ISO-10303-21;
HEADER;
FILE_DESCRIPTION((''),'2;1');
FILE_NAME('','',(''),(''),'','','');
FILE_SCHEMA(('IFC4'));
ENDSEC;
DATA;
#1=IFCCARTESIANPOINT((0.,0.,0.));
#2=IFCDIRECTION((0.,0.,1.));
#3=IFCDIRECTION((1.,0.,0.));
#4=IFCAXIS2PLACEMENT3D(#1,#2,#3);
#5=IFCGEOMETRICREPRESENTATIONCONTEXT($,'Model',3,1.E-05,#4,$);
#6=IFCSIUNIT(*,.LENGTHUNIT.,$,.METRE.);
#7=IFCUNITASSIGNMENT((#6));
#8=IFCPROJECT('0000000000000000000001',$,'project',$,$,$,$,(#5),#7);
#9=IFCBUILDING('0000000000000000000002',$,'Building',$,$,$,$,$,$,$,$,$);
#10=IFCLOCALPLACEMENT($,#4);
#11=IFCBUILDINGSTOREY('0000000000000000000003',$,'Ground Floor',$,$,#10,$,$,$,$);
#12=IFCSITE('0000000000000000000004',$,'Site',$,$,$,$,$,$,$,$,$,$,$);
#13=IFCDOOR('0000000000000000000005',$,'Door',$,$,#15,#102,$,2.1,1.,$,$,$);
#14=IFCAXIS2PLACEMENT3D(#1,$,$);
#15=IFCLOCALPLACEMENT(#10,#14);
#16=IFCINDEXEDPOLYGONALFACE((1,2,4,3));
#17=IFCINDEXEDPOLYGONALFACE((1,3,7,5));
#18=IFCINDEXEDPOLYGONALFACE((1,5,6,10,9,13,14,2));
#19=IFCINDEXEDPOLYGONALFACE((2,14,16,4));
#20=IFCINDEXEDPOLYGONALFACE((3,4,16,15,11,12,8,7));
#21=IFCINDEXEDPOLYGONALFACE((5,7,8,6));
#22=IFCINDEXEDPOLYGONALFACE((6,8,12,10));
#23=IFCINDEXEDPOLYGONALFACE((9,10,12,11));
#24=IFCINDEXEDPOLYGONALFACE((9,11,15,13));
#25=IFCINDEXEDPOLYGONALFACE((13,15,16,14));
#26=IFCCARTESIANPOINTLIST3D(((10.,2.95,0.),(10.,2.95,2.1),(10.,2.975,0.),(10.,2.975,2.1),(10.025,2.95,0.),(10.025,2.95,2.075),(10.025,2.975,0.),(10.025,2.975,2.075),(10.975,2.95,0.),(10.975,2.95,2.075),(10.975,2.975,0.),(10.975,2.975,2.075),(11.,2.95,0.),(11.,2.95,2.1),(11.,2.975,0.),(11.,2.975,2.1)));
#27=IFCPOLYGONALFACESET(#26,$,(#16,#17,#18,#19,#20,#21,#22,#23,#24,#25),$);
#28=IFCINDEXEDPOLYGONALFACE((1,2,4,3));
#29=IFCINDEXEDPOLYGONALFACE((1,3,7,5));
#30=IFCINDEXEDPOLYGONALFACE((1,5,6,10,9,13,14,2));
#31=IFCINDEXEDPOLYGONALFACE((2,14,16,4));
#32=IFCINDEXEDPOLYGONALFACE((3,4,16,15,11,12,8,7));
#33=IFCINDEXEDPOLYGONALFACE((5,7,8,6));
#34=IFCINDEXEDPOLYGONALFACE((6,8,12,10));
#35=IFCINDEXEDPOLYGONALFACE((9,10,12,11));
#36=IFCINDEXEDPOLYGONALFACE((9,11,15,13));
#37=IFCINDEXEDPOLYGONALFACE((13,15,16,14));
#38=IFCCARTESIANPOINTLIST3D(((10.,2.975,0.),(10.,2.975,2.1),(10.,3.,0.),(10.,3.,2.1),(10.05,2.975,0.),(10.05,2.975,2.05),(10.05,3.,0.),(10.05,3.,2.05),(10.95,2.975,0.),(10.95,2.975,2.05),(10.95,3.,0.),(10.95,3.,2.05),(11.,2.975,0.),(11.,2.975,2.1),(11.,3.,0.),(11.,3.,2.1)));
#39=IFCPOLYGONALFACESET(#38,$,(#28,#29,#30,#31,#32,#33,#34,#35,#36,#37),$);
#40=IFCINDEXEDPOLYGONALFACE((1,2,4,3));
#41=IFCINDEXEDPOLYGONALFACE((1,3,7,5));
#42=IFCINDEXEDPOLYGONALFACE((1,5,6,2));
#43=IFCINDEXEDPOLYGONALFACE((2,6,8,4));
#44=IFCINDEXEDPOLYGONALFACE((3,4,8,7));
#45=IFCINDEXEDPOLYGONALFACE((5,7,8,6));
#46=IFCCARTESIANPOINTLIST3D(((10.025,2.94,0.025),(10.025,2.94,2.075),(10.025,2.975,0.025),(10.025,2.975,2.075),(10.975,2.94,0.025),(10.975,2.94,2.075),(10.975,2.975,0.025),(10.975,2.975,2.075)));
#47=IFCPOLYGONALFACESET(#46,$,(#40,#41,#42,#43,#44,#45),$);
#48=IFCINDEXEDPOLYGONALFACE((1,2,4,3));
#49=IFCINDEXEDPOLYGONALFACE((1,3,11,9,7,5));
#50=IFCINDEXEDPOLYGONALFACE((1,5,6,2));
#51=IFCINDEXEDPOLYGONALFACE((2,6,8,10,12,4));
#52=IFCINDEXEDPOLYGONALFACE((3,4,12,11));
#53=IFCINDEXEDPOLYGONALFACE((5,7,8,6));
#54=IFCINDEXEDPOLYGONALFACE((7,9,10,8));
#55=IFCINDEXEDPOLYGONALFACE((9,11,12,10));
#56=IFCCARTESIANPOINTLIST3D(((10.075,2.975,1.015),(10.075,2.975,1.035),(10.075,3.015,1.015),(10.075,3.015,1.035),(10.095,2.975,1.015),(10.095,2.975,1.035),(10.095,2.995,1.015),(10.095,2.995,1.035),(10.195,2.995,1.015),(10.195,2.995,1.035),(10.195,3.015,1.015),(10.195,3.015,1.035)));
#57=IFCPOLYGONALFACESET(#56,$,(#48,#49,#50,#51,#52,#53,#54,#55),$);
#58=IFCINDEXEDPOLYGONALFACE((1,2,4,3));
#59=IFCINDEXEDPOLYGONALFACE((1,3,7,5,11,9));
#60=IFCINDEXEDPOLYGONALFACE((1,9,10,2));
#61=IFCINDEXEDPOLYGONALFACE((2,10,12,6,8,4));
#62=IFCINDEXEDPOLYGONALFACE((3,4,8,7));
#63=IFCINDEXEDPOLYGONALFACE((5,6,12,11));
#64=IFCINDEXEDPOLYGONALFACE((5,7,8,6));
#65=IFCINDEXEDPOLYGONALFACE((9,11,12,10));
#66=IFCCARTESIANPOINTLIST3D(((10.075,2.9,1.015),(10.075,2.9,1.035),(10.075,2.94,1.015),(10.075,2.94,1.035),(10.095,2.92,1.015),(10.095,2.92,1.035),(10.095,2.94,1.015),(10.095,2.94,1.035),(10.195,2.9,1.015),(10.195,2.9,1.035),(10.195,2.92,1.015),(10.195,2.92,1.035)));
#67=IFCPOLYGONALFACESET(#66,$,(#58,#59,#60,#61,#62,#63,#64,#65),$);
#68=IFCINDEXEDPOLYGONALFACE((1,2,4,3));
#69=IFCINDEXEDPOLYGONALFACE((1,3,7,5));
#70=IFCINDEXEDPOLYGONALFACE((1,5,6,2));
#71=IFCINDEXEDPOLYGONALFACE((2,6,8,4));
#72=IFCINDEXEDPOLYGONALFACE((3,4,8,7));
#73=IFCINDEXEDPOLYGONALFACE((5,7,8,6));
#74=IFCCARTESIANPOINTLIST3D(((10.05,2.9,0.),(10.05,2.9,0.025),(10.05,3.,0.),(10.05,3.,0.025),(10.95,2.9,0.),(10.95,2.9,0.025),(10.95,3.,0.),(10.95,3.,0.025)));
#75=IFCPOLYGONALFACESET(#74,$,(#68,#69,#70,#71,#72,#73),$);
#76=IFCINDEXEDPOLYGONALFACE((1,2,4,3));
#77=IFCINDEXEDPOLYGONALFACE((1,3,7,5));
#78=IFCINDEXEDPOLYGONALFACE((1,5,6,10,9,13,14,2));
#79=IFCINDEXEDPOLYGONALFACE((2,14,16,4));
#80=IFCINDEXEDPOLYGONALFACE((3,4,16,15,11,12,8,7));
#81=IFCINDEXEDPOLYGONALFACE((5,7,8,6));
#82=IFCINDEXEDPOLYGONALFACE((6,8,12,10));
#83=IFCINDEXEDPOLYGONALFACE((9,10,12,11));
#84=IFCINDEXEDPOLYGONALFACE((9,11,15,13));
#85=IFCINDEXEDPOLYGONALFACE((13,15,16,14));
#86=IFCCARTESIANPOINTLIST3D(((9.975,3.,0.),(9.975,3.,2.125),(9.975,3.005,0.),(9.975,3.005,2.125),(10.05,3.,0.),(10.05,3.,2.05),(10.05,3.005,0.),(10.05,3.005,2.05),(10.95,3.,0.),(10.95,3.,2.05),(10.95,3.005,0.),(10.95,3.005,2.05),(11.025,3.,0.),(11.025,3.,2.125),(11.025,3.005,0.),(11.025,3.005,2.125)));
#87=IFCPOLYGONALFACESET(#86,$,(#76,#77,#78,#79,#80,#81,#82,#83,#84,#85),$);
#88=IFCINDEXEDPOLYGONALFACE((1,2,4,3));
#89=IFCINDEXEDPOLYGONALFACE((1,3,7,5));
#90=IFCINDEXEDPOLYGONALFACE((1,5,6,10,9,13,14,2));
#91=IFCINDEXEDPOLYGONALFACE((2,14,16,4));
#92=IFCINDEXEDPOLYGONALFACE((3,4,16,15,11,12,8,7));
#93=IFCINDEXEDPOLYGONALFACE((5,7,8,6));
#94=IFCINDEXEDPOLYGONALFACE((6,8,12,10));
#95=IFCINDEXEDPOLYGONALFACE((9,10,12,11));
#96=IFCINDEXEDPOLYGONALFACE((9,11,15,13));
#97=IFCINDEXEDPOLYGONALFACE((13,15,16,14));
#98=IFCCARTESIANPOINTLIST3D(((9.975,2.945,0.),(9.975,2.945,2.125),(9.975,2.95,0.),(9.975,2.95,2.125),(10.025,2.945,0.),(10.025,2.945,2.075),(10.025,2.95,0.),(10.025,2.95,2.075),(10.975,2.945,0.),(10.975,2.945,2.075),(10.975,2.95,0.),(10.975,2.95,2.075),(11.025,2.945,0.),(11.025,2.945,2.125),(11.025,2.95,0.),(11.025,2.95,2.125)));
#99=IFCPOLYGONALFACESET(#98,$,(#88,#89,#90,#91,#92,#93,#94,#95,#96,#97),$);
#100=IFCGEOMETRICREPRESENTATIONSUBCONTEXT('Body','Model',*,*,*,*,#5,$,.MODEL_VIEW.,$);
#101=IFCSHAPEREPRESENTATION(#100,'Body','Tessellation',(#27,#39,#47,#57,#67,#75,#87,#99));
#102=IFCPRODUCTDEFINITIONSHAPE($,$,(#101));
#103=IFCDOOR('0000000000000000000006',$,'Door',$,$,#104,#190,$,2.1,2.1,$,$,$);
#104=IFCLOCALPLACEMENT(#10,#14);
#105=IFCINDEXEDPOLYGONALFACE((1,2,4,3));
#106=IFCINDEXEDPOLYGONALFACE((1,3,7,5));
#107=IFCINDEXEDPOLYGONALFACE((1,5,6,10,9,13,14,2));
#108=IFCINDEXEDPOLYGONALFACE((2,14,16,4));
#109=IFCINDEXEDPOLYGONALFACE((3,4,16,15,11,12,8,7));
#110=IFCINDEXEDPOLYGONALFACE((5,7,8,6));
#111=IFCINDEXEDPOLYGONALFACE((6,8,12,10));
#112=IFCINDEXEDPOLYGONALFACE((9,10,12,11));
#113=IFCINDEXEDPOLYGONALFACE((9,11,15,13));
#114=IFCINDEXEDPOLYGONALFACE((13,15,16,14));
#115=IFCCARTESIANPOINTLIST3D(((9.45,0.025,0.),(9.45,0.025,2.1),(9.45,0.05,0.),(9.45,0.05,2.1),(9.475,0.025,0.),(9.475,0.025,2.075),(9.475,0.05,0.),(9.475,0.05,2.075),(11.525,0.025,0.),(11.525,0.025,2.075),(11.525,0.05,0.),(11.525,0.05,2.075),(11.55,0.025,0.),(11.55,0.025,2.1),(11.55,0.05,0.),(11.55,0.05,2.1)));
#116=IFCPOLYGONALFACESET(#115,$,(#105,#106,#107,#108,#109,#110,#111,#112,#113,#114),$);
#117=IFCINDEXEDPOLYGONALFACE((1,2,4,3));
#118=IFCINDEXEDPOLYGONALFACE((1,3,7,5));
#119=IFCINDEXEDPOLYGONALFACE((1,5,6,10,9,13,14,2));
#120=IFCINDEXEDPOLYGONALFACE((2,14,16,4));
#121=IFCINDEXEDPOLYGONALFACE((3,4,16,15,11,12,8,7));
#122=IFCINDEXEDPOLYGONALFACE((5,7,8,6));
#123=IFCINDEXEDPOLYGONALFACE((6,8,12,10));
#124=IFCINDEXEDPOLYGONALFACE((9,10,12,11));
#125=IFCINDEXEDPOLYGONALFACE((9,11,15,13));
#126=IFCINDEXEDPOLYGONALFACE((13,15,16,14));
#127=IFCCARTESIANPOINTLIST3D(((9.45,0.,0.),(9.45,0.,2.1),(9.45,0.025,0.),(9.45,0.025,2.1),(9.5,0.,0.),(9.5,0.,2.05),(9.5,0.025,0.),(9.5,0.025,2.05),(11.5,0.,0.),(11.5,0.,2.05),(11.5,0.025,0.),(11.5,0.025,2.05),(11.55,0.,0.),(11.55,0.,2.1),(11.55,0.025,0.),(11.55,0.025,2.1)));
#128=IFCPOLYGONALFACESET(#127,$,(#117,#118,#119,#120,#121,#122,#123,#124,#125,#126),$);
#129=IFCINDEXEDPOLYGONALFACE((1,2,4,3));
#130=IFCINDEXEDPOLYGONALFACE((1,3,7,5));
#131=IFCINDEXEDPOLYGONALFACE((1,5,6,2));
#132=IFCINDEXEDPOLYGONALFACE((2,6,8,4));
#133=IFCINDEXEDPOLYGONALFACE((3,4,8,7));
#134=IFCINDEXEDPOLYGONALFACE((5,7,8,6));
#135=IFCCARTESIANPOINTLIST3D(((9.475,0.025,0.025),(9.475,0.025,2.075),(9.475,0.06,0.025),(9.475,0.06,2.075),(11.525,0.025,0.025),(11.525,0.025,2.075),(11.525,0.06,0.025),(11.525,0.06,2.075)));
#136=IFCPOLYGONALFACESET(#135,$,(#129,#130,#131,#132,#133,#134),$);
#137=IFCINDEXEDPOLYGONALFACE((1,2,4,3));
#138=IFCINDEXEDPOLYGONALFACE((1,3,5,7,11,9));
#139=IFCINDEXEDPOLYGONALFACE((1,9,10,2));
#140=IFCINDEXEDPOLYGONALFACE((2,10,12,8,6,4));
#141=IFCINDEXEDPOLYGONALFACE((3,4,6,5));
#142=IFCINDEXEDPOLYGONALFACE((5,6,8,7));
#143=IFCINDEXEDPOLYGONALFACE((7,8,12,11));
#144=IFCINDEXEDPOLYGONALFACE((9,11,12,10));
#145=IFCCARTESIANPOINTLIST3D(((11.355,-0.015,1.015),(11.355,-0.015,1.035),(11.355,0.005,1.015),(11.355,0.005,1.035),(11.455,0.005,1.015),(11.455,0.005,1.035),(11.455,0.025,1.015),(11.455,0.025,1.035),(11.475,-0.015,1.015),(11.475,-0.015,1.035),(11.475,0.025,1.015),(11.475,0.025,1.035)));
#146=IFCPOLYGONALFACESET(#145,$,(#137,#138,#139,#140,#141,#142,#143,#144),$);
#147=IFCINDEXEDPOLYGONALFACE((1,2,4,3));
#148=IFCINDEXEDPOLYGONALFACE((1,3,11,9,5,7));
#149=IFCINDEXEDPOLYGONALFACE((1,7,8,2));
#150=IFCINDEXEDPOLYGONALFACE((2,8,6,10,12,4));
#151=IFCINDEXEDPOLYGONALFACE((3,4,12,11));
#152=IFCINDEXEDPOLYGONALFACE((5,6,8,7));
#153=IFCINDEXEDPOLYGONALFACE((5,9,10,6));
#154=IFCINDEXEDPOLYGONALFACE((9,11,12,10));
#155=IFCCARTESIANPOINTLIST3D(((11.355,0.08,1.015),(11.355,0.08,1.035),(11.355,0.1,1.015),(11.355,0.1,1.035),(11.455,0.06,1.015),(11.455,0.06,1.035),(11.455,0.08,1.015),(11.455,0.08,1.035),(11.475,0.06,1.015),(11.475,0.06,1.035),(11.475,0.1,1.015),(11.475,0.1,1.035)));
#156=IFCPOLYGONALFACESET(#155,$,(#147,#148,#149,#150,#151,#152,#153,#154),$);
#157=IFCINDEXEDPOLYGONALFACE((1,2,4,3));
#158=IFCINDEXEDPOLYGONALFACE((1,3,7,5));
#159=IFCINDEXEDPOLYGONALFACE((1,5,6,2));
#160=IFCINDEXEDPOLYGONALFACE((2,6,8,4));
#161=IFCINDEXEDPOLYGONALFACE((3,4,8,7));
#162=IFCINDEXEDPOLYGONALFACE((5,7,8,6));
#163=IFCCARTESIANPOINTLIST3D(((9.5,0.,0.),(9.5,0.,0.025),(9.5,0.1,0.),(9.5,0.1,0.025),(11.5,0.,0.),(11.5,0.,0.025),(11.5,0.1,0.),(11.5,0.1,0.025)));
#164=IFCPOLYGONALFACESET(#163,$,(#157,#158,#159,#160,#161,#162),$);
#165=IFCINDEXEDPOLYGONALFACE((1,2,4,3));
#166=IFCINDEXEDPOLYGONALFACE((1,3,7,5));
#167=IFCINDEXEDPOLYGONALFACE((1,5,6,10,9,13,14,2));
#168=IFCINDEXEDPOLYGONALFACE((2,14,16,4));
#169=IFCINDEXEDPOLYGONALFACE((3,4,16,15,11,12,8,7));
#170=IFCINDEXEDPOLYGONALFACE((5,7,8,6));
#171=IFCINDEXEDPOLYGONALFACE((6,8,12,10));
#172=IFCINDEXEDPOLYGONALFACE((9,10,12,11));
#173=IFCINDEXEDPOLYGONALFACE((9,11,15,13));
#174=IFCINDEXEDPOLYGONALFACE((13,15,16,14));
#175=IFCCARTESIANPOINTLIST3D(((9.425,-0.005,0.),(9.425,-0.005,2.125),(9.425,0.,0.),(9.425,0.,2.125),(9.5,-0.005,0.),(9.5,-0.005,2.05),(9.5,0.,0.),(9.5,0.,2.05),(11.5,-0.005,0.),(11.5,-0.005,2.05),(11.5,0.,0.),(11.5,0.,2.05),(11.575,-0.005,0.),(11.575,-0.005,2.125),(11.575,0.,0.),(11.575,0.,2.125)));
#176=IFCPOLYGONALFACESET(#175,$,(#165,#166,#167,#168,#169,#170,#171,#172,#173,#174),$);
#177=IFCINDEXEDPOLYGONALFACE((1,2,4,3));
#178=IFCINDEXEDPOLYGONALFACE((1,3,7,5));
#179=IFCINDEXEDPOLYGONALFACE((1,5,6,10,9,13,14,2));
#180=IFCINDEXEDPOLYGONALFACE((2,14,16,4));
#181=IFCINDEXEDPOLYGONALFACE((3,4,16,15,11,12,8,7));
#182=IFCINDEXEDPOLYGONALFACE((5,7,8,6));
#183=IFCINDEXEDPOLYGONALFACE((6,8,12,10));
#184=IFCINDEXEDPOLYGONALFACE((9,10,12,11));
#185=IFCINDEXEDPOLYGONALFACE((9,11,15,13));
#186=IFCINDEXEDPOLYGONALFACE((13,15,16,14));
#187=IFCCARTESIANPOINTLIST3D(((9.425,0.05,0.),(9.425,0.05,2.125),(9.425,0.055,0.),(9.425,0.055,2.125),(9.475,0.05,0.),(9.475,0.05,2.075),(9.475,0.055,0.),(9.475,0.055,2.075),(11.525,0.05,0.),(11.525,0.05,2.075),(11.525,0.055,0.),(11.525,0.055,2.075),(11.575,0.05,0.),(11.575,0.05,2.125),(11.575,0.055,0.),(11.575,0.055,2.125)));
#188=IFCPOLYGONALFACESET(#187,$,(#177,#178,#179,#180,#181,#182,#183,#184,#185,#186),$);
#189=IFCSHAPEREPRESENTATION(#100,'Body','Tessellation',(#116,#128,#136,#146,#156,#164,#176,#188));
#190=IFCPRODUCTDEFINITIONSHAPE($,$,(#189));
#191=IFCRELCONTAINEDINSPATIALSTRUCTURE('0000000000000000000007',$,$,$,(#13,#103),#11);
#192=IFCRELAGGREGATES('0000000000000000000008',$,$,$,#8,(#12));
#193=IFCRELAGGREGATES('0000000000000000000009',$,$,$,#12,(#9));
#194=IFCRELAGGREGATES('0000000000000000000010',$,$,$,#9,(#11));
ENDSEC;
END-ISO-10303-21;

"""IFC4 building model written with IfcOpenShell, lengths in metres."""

from ifc_helpers import new_model, si_unit, frame, origin_with_axes, place, context, subcontext, project, spatial, line, indexed_curve, outline, extrude, element, save


model = new_model("IFC4")

# Units and contexts
model_context = context("Model", 3, precision=1e-05, world=origin_with_axes())
body_context = subcontext(model_context, "Body", "Model", "MODEL_VIEW")
ifc_project = project(units=[si_unit("LENGTHUNIT", "METRE")], contexts=[model_context])

# Site, building, storey
site = spatial("IfcSite", under=ifc_project, Name="Site")
building = spatial("IfcBuilding", under=site, Name="Building")
storey_placement = place(None, origin_with_axes())
storey = spatial("IfcBuildingStorey", under=building, at=storey_placement, Name="Ground Floor")

# Doors
door_1_placement = place(storey_placement, frame((11.0, 3.0, 0.0), z_axis=(0.0, 0.0, 1.0), x_axis=(-1.0, 0.0, 0.0)))
element("IfcDoor", 1, at=door_1_placement, inside=storey, Name="Door", OverallHeight=2.1, OverallWidth=1.0, context=body_context, shape_type="SweptSolid", body=[
    extrude(outline(indexed_curve([(0.0, 0.0), (0.0, 2.1), (1.0, 2.1), (1.0, 0.0), (0.975, 0.0), (0.975, 2.075), (0.025, 2.075), (0.025, 0.0)], segments=[line(1, 2, 3, 4, 5, 6, 7, 8, 1)])), frame((0.0, 0.025, 0.0), z_axis=(0.0, -1.0, 0.0), x_axis=(1.0, 0.0, 0.0)), (0.0, 0.0, -1.0), 0.025),
    extrude(outline(indexed_curve([(0.0, 0.0), (0.0, 2.1), (1.0, 2.1), (1.0, 0.0), (0.95, 0.0), (0.95, 2.05), (0.05, 2.05), (0.05, 0.0)], segments=[line(1, 2, 3, 4, 5, 6, 7, 8, 1)])), frame((0.0, 0.0, 0.0), z_axis=(0.0, -1.0, 0.0), x_axis=(1.0, 0.0, 0.0)), (0.0, 0.0, -1.0), 0.025),
    extrude(outline(indexed_curve([(0.0, 0.0), (0.95, 0.0), (0.95, 0.035), (0.0, 0.035)], segments=[line(1, 2, 3, 4, 1)])), frame((0.025, 0.025, 0.025), z_axis=(0.0, 0.0, 1.0), x_axis=(1.0, 0.0, 0.0)), (0.0, 0.0, 1.0), 2.05),
    extrude(outline(indexed_curve([(0.0, 0.0), (0.0, -0.04), (-0.12, -0.04), (-0.12, -0.02), (-0.02, -0.02), (-0.02, 0.0)], segments=[line(1, 2, 3, 4, 5, 6, 1)])), frame((0.925, 0.025, 1.015), z_axis=(0.0, 0.0, 1.0), x_axis=(1.0, 0.0, 0.0)), (0.0, 0.0, 1.0), 0.02),
    extrude(outline(indexed_curve([(0.0, 0.0), (0.0, 0.04), (-0.12, 0.04), (-0.12, 0.02), (-0.02, 0.02), (-0.02, 0.0)], segments=[line(1, 2, 3, 4, 5, 6, 1)])), frame((0.925, 0.06, 1.015), z_axis=(0.0, 0.0, 1.0), x_axis=(1.0, 0.0, 0.0)), (0.0, 0.0, 1.0), 0.02),
    extrude(outline(indexed_curve([(0.0, 0.0), (0.9, 0.0), (0.9, 0.1), (0.0, 0.1)], segments=[line(1, 2, 3, 4, 1)])), frame((0.05, 0.0, 0.0), z_axis=(0.0, 0.0, 1.0), x_axis=(1.0, 0.0, 0.0)), (0.0, 0.0, 1.0), 0.025),
    extrude(outline(indexed_curve([(0.0, 0.0), (0.0, 2.125), (1.05, 2.125), (1.05, 0.0), (0.975, 0.0), (0.975, 2.05), (0.075, 2.05), (0.075, 0.0)], segments=[line(1, 2, 3, 4, 5, 6, 7, 8, 1)])), frame((-0.025, -0.005, 0.0), z_axis=(0.0, -1.0, 0.0), x_axis=(1.0, 0.0, 0.0)), (0.0, 0.0, -1.0), 0.005),
    extrude(outline(indexed_curve([(0.0, 0.0), (0.0, 2.125), (1.05, 2.125), (1.05, 0.0), (1.0, 0.0), (1.0, 2.075), (0.05, 2.075), (0.05, 0.0)], segments=[line(1, 2, 3, 4, 5, 6, 7, 8, 1)])), frame((-0.025, 0.05, 0.0), z_axis=(0.0, -1.0, 0.0), x_axis=(1.0, 0.0, 0.0)), (0.0, 0.0, -1.0), 0.005),
])
door_2_placement = place(storey_placement, frame((9.45, 0.0, 0.0), z_axis=(0.0, 0.0, 1.0), x_axis=(1.0, 0.0, 0.0)))
element("IfcDoor", 2, at=door_2_placement, inside=storey, Name="Door", OverallHeight=2.1, OverallWidth=2.1, context=body_context, shape_type="SweptSolid", body=[
    extrude(outline(indexed_curve([(0.0, 0.0), (0.0, 2.1), (2.1, 2.1), (2.1, 0.0), (2.075, 0.0), (2.075, 2.075), (0.025, 2.075), (0.025, 0.0)], segments=[line(1, 2, 3, 4, 5, 6, 7, 8, 1)])), frame((0.0, 0.025, 0.0), z_axis=(0.0, -1.0, 0.0), x_axis=(1.0, 0.0, 0.0)), (0.0, 0.0, -1.0), 0.025),
    extrude(outline(indexed_curve([(0.0, 0.0), (0.0, 2.1), (2.1, 2.1), (2.1, 0.0), (2.05, 0.0), (2.05, 2.05), (0.05, 2.05), (0.05, 0.0)], segments=[line(1, 2, 3, 4, 5, 6, 7, 8, 1)])), frame((0.0, 0.0, 0.0), z_axis=(0.0, -1.0, 0.0), x_axis=(1.0, 0.0, 0.0)), (0.0, 0.0, -1.0), 0.025),
    extrude(outline(indexed_curve([(0.0, 0.0), (2.05, 0.0), (2.05, 0.035), (0.0, 0.035)], segments=[line(1, 2, 3, 4, 1)])), frame((0.025, 0.025, 0.025), z_axis=(0.0, 0.0, 1.0), x_axis=(1.0, 0.0, 0.0)), (0.0, 0.0, 1.0), 2.05),
    extrude(outline(indexed_curve([(0.0, 0.0), (0.0, -0.04), (-0.12, -0.04), (-0.12, -0.02), (-0.02, -0.02), (-0.02, 0.0)], segments=[line(1, 2, 3, 4, 5, 6, 1)])), frame((2.025, 0.025, 1.015), z_axis=(0.0, 0.0, 1.0), x_axis=(1.0, 0.0, 0.0)), (0.0, 0.0, 1.0), 0.02),
    extrude(outline(indexed_curve([(0.0, 0.0), (0.0, 0.04), (-0.12, 0.04), (-0.12, 0.02), (-0.02, 0.02), (-0.02, 0.0)], segments=[line(1, 2, 3, 4, 5, 6, 1)])), frame((2.025, 0.06, 1.015), z_axis=(0.0, 0.0, 1.0), x_axis=(1.0, 0.0, 0.0)), (0.0, 0.0, 1.0), 0.02),
    extrude(outline(indexed_curve([(0.0, 0.0), (2.0, 0.0), (2.0, 0.1), (0.0, 0.1)], segments=[line(1, 2, 3, 4, 1)])), frame((0.05, 0.0, 0.0), z_axis=(0.0, 0.0, 1.0), x_axis=(1.0, 0.0, 0.0)), (0.0, 0.0, 1.0), 0.025),
    extrude(outline(indexed_curve([(0.0, 0.0), (0.0, 2.125), (2.15, 2.125), (2.15, 0.0), (2.075, 0.0), (2.075, 2.05), (0.075, 2.05), (0.075, 0.0)], segments=[line(1, 2, 3, 4, 5, 6, 7, 8, 1)])), frame((-0.025, -0.005, 0.0), z_axis=(0.0, -1.0, 0.0), x_axis=(1.0, 0.0, 0.0)), (0.0, 0.0, -1.0), 0.005),
    extrude(outline(indexed_curve([(0.0, 0.0), (0.0, 2.125), (2.15, 2.125), (2.15, 0.0), (2.1, 0.0), (2.1, 2.075), (0.05, 2.075), (0.05, 0.0)], segments=[line(1, 2, 3, 4, 5, 6, 7, 8, 1)])), frame((-0.025, 0.05, 0.0), z_axis=(0.0, -1.0, 0.0), x_axis=(1.0, 0.0, 0.0)), (0.0, 0.0, -1.0), 0.005),
])

save(model, "model.ifc")
